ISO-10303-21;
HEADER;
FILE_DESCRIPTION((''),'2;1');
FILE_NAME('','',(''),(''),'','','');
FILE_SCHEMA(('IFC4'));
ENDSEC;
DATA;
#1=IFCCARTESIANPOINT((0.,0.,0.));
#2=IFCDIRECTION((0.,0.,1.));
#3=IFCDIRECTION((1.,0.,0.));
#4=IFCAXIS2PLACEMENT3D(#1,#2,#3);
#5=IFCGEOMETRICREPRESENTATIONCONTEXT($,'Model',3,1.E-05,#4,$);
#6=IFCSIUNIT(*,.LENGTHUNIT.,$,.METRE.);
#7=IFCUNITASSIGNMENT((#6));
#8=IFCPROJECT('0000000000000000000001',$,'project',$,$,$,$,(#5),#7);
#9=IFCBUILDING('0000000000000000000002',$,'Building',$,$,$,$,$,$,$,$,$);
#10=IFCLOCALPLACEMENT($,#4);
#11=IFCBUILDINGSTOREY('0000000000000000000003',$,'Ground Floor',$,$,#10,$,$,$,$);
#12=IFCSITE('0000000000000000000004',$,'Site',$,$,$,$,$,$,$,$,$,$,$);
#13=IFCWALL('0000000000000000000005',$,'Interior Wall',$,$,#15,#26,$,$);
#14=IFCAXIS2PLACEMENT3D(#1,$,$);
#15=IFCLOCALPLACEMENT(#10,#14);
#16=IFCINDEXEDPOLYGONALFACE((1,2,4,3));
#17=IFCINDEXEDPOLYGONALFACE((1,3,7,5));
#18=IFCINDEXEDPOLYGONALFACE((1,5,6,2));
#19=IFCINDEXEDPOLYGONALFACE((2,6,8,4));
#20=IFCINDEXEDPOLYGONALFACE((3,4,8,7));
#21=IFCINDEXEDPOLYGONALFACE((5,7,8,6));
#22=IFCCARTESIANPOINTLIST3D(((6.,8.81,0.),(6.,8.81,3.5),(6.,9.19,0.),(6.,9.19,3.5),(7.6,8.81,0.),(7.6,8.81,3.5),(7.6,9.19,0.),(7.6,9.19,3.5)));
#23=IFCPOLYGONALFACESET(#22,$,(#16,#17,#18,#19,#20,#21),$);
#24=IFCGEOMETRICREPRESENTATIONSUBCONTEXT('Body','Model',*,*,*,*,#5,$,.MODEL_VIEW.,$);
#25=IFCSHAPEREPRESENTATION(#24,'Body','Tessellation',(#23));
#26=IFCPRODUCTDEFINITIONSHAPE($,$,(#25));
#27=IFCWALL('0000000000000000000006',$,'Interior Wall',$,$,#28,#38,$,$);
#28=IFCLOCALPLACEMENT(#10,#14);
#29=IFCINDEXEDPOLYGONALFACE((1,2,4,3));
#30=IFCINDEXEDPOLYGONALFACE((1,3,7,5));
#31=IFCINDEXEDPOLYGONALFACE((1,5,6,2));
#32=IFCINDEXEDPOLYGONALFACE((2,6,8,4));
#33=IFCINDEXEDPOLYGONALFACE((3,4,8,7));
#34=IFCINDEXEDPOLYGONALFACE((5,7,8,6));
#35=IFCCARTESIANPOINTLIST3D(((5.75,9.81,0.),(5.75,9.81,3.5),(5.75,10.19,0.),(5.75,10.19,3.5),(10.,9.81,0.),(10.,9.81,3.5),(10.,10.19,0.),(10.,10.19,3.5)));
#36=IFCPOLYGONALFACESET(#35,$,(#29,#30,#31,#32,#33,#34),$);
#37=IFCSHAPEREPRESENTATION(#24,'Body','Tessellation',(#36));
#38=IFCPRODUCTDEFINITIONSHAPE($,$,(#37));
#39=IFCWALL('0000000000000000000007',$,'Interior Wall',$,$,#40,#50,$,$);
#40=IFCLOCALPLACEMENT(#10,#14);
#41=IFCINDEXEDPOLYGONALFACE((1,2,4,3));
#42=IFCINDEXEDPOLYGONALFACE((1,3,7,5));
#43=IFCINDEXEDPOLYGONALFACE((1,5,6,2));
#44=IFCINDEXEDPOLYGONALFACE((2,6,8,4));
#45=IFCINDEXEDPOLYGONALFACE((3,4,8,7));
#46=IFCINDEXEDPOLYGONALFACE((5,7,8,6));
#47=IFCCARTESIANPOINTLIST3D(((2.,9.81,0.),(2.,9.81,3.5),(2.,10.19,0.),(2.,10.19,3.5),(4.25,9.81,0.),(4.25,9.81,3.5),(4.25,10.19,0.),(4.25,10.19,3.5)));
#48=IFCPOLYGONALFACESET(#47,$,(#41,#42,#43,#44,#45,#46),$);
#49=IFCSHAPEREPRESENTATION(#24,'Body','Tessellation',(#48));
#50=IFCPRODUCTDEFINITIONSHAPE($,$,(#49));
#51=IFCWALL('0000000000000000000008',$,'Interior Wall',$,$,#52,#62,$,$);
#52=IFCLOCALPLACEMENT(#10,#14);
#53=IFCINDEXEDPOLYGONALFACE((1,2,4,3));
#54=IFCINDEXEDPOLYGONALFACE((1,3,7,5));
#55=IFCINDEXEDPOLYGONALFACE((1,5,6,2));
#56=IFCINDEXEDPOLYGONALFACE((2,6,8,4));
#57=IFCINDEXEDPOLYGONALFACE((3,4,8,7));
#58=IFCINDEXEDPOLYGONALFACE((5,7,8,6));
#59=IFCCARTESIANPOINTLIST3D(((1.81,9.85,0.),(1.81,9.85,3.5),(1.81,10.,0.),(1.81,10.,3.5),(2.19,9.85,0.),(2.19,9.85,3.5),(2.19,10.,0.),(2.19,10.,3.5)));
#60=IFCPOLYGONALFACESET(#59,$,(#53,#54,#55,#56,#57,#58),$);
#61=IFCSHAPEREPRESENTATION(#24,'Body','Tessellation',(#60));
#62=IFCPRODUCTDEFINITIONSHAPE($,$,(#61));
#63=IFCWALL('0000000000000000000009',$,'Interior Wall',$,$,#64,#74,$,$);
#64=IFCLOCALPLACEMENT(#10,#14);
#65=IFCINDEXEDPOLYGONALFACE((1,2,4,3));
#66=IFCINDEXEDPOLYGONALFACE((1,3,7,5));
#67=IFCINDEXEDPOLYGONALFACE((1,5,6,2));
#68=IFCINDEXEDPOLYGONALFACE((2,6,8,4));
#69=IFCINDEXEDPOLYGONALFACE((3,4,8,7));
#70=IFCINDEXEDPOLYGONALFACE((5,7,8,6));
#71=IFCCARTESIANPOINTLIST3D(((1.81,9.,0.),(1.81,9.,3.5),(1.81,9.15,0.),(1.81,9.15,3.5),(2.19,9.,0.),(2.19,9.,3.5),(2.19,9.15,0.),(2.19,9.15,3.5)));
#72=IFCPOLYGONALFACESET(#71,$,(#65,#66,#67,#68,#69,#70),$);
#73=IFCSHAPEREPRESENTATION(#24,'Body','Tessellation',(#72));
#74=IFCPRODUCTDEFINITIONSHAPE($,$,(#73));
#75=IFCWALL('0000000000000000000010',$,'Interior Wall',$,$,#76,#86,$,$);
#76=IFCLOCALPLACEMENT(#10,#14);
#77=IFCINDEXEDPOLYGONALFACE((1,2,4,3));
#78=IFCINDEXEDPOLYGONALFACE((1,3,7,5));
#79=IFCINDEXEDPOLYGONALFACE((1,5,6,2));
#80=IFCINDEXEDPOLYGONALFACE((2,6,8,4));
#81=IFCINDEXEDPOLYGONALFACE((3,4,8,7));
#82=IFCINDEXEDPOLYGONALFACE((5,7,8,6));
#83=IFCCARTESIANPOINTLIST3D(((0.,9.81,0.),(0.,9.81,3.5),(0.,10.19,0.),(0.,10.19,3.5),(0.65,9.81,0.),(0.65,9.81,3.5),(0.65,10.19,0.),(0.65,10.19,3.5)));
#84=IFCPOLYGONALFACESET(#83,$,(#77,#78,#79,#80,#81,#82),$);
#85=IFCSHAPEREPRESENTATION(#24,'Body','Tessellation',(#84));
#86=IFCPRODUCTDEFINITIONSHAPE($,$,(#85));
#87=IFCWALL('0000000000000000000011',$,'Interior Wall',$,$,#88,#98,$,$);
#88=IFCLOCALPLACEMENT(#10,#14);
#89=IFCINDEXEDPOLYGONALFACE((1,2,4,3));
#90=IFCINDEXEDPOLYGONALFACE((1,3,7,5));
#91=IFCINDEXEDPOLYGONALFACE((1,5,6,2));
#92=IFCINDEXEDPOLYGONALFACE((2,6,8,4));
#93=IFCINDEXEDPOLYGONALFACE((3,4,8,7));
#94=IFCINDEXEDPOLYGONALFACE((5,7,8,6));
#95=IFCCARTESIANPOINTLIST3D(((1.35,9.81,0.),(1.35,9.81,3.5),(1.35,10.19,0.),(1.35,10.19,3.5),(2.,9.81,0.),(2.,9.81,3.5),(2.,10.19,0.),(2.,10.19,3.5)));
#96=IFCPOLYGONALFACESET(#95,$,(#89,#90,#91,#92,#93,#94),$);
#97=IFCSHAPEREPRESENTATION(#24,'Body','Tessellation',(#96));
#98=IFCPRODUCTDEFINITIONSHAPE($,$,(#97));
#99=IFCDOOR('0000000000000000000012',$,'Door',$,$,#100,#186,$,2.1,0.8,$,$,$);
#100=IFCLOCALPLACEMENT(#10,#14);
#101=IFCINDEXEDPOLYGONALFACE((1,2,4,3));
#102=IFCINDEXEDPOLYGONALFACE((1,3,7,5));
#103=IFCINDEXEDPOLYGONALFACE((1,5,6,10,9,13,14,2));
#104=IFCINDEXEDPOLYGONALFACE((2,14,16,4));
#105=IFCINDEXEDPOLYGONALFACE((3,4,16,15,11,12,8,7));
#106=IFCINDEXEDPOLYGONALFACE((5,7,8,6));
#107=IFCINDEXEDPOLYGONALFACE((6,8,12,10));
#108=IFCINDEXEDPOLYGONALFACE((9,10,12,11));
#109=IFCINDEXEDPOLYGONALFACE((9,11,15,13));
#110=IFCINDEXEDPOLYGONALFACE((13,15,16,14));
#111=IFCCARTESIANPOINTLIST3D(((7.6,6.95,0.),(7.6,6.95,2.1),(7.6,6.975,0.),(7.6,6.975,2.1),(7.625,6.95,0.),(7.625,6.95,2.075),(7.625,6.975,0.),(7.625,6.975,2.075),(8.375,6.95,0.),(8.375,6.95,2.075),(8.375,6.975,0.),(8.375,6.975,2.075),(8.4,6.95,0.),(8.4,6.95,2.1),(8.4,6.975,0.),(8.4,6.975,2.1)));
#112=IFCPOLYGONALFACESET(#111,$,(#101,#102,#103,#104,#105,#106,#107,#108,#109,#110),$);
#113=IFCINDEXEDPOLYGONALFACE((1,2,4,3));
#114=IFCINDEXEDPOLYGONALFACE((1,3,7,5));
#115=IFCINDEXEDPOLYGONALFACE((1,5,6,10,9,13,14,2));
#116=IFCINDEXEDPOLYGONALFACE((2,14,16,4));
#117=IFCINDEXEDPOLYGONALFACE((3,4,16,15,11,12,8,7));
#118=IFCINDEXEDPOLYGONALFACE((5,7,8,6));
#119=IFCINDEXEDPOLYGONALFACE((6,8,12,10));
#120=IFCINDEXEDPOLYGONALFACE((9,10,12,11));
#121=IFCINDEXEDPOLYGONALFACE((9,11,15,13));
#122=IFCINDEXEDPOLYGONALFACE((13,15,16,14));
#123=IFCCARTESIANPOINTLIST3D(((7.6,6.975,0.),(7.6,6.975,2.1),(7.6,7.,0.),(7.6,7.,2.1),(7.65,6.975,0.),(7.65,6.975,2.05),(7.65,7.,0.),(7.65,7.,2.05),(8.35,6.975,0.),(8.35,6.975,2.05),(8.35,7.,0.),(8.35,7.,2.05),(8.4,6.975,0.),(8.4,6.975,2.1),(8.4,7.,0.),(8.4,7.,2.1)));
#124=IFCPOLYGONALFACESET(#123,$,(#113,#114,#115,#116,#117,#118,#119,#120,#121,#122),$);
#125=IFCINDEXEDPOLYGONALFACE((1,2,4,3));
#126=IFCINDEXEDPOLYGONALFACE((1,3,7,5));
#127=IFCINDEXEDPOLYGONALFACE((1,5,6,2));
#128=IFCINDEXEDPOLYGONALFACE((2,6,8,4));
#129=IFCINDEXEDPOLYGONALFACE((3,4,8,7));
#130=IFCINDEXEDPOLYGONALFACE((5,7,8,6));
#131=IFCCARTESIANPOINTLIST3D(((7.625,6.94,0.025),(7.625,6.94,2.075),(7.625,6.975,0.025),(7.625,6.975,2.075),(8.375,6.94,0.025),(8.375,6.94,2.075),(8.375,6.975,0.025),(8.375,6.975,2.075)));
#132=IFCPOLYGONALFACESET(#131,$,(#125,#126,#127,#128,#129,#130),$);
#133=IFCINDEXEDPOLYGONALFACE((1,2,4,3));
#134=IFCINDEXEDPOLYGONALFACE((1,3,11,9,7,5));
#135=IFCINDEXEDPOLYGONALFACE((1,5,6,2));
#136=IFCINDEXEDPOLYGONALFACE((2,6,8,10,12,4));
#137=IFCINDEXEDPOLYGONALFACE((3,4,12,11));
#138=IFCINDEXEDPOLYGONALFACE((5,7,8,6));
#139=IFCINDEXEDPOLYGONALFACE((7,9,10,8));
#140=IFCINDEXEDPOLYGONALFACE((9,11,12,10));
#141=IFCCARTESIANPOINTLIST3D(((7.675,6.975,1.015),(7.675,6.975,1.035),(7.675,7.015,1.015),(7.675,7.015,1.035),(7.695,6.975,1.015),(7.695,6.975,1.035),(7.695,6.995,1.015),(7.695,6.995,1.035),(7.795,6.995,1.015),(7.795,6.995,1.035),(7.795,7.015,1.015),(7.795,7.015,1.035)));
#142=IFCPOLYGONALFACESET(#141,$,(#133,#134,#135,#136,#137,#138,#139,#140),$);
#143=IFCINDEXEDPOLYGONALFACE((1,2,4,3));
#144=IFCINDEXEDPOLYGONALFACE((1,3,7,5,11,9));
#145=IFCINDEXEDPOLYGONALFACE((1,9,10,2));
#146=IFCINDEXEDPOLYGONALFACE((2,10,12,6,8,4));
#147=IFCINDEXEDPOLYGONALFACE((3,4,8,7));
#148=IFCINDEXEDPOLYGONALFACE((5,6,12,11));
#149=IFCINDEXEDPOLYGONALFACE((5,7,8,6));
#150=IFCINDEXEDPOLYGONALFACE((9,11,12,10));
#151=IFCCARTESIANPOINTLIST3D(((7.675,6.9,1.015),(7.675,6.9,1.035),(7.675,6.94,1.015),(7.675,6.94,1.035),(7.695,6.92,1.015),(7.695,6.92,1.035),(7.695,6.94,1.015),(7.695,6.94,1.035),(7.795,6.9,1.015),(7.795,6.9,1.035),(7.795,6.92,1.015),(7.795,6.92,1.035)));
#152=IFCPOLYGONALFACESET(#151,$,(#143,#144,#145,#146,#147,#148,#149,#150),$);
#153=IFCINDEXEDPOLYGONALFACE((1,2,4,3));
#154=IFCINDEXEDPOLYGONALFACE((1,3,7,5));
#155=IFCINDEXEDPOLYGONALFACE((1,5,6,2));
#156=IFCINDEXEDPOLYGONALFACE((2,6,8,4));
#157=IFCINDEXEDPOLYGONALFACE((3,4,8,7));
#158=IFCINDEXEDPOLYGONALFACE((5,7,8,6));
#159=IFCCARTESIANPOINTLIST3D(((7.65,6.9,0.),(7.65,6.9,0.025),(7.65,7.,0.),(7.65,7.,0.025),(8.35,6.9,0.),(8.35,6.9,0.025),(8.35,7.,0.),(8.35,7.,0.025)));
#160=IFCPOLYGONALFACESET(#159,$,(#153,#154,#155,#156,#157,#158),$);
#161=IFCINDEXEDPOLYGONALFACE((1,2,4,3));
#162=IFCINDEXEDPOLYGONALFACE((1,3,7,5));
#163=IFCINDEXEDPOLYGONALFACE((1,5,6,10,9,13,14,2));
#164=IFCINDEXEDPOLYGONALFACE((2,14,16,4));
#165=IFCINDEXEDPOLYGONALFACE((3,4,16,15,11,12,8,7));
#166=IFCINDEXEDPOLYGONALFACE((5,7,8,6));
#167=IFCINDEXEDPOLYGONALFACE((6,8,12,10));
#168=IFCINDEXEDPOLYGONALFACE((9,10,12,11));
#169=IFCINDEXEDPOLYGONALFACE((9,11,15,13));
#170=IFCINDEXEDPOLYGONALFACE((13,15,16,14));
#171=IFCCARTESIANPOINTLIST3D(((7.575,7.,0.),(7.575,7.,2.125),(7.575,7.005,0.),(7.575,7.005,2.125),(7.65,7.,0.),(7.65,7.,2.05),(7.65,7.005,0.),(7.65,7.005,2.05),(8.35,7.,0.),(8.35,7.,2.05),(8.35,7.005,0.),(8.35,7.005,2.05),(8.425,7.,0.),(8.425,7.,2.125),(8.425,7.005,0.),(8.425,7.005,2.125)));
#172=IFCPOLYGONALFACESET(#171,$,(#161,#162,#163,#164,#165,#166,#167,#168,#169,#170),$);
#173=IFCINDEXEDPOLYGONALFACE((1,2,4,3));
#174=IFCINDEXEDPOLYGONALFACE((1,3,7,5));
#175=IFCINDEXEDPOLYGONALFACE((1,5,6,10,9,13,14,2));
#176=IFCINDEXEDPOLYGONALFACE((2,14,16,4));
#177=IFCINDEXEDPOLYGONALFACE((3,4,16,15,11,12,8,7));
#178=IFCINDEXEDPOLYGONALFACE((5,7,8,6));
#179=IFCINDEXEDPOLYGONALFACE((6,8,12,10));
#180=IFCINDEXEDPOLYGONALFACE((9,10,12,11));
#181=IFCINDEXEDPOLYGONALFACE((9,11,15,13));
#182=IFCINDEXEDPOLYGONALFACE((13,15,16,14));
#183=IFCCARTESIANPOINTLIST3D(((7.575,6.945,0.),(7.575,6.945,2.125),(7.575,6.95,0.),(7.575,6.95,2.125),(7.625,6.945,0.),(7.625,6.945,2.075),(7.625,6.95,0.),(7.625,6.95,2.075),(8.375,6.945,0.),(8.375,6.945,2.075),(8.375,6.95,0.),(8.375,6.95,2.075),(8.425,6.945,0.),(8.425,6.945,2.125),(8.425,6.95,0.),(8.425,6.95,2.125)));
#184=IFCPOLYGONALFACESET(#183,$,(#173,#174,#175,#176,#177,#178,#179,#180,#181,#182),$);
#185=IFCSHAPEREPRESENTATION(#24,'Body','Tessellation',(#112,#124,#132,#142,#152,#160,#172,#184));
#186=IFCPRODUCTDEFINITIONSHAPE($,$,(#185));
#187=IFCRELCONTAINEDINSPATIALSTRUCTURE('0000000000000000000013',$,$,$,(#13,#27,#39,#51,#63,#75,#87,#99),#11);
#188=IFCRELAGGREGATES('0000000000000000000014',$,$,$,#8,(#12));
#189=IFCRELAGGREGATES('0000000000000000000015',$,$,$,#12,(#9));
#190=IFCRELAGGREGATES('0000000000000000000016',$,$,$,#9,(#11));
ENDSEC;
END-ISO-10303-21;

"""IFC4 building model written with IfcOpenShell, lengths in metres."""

from ifc_helpers import new_model, si_unit, frame, origin_with_axes, place, context, subcontext, project, spatial, line, indexed_curve, outline, extrude, element, save


model = new_model("IFC4")

# Units and contexts
model_context = context("Model", 3, precision=1e-05, world=origin_with_axes())
body_context = subcontext(model_context, "Body", "Model", "MODEL_VIEW")
ifc_project = project(units=[si_unit("LENGTHUNIT", "METRE")], contexts=[model_context])

# Site, building, storey
site = spatial("IfcSite", under=ifc_project, Name="Site")
building = spatial("IfcBuilding", under=site, Name="Building")
storey_placement = place(None, origin_with_axes())
storey = spatial("IfcBuildingStorey", under=building, at=storey_placement, Name="Ground Floor")

# Walls
for number, where, z_axis, x_axis, name in (
    (1, (7.6, 9.0, 0.0), (0.0, 0.0, 1.0), (-1.0, 0.0, 0.0), "Interior Wall"),
):
    element("IfcWall", number, at=place(storey_placement, frame(where, z_axis=z_axis, x_axis=x_axis)), inside=storey, Name=name, context=body_context, shape_type="SweptSolid", body=[
        extrude(outline(indexed_curve([(0.0, 0.0), (0.0, 0.38), (1.6, 0.38), (1.6, 0.0), (0.0, 0.0)], self_intersect=False)), frame((0.0, -0.19, 0.0), z_axis=(0.0, 0.0, 1.0), x_axis=(1.0, 0.0, 0.0)), (0.0, 0.0, 1.0), 3.5),
    ])
wall_1_placement = place(storey_placement, frame((10.0, 10.0, 0.0), z_axis=(0.0, 0.0, 1.0), x_axis=(-1.0, 0.0, 0.0)))
element("IfcWall", 2, at=wall_1_placement, inside=storey, Name="Interior Wall", context=body_context, shape_type="SweptSolid", body=[
    extrude(outline(indexed_curve([(0.0, 0.0), (0.0, 0.38), (4.25, 0.38), (4.25, 0.0), (0.0, 0.0)], self_intersect=False)), frame((0.0, -0.19, 0.0), z_axis=(0.0, 0.0, 1.0), x_axis=(1.0, 0.0, 0.0)), (0.0, 0.0, 1.0), 3.5),
])
wall_2_placement = place(storey_placement, frame((4.25, 10.0, 0.0), z_axis=(0.0, 0.0, 1.0), x_axis=(-1.0, 0.0, 0.0)))
element("IfcWall", 3, at=wall_2_placement, inside=storey, Name="Interior Wall", context=body_context, shape_type="SweptSolid", body=[
    extrude(outline(indexed_curve([(0.0, 0.0), (0.0, 0.38), (2.25, 0.38), (2.25, 0.0), (0.0, 0.0)], self_intersect=False)), frame((0.0, -0.19, 0.0), z_axis=(0.0, 0.0, 1.0), x_axis=(1.0, 0.0, 0.0)), (0.0, 0.0, 1.0), 3.5),
])
for number, where, z_axis, x_axis, name in (
    (4, (2.0, 10.0, 0.0), (0.0, 0.0, 1.0), (0.0, -1.0, 0.0), "Interior Wall"),
    (5, (2.0, 9.15, 0.0), (0.0, 0.0, 1.0), (0.0, -1.0, 0.0), "Interior Wall"),
):
    element("IfcWall", number, at=place(storey_placement, frame(where, z_axis=z_axis, x_axis=x_axis)), inside=storey, Name=name, context=body_context, shape_type="SweptSolid", body=[
        extrude(outline(indexed_curve([(0.0, 0.0), (0.0, 0.38), (0.15, 0.38), (0.15, 0.0), (0.0, 0.0)], self_intersect=False)), frame((0.0, -0.19, 0.0), z_axis=(0.0, 0.0, 1.0), x_axis=(1.0, 0.0, 0.0)), (0.0, 0.0, 1.0), 3.5),
    ])
wall_3_placement = place(storey_placement, frame((0.0, 10.0, 0.0), z_axis=(0.0, 0.0, 1.0), x_axis=(1.0, 0.0, 0.0)))
element("IfcWall", 6, at=wall_3_placement, inside=storey, Name="Interior Wall", context=body_context, shape_type="SweptSolid", body=[
    extrude(outline(indexed_curve([(0.0, 0.0), (0.0, 0.38), (0.65, 0.38), (0.65, 0.0), (0.0, 0.0)], self_intersect=False)), frame((0.0, -0.19, 0.0), z_axis=(0.0, 0.0, 1.0), x_axis=(1.0, 0.0, 0.0)), (0.0, 0.0, 1.0), 3.5),
])
wall_4_placement = place(storey_placement, frame((1.35, 10.0, 0.0), z_axis=(0.0, 0.0, 1.0), x_axis=(1.0, 0.0, 0.0)))
element("IfcWall", 7, at=wall_4_placement, inside=storey, Name="Interior Wall", context=body_context, shape_type="SweptSolid", body=[
    extrude(outline(indexed_curve([(0.0, 0.0), (0.0, 0.38), (0.65, 0.38), (0.65, 0.0), (0.0, 0.0)], self_intersect=False)), frame((0.0, -0.19, 0.0), z_axis=(0.0, 0.0, 1.0), x_axis=(1.0, 0.0, 0.0)), (0.0, 0.0, 1.0), 3.5),
])

# Door
door_1_placement = place(storey_placement, frame((8.4, 7.0, 0.0), z_axis=(0.0, 0.0, 1.0), x_axis=(-1.0, 0.0, 0.0)))
element("IfcDoor", 8, at=door_1_placement, inside=storey, Name="Door", OverallHeight=2.1, OverallWidth=0.8, context=body_context, shape_type="SweptSolid", body=[
    extrude(outline(indexed_curve([(0.0, 0.0), (0.0, 2.1), (0.8, 2.1), (0.8, 0.0), (0.775, 0.0), (0.775, 2.075), (0.025, 2.075), (0.025, 0.0)], segments=[line(1, 2, 3, 4, 5, 6, 7, 8, 1)])), frame((0.0, 0.025, 0.0), z_axis=(0.0, -1.0, 0.0), x_axis=(1.0, 0.0, 0.0)), (0.0, 0.0, -1.0), 0.025),
    extrude(outline(indexed_curve([(0.0, 0.0), (0.0, 2.1), (0.8, 2.1), (0.8, 0.0), (0.75, 0.0), (0.75, 2.05), (0.05, 2.05), (0.05, 0.0)], segments=[line(1, 2, 3, 4, 5, 6, 7, 8, 1)])), frame((0.0, 0.0, 0.0), z_axis=(0.0, -1.0, 0.0), x_axis=(1.0, 0.0, 0.0)), (0.0, 0.0, -1.0), 0.025),
    extrude(outline(indexed_curve([(0.0, 0.0), (0.75, 0.0), (0.75, 0.035), (0.0, 0.035)], segments=[line(1, 2, 3, 4, 1)])), frame((0.025, 0.025, 0.025), z_axis=(0.0, 0.0, 1.0), x_axis=(1.0, 0.0, 0.0)), (0.0, 0.0, 1.0), 2.05),
    extrude(outline(indexed_curve([(0.0, 0.0), (0.0, -0.04), (-0.12, -0.04), (-0.12, -0.02), (-0.02, -0.02), (-0.02, 0.0)], segments=[line(1, 2, 3, 4, 5, 6, 1)])), frame((0.725, 0.025, 1.015), z_axis=(0.0, 0.0, 1.0), x_axis=(1.0, 0.0, 0.0)), (0.0, 0.0, 1.0), 0.02),
    extrude(outline(indexed_curve([(0.0, 0.0), (0.0, 0.04), (-0.12, 0.04), (-0.12, 0.02), (-0.02, 0.02), (-0.02, 0.0)], segments=[line(1, 2, 3, 4, 5, 6, 1)])), frame((0.725, 0.06, 1.015), z_axis=(0.0, 0.0, 1.0), x_axis=(1.0, 0.0, 0.0)), (0.0, 0.0, 1.0), 0.02),
    extrude(outline(indexed_curve([(0.0, 0.0), (0.7, 0.0), (0.7, 0.1), (0.0, 0.1)], segments=[line(1, 2, 3, 4, 1)])), frame((0.05, 0.0, 0.0), z_axis=(0.0, 0.0, 1.0), x_axis=(1.0, 0.0, 0.0)), (0.0, 0.0, 1.0), 0.025),
    extrude(outline(indexed_curve([(0.0, 0.0), (0.0, 2.125), (0.85, 2.125), (0.85, 0.0), (0.775, 0.0), (0.775, 2.05), (0.075, 2.05), (0.075, 0.0)], segments=[line(1, 2, 3, 4, 5, 6, 7, 8, 1)])), frame((-0.025, -0.005, 0.0), z_axis=(0.0, -1.0, 0.0), x_axis=(1.0, 0.0, 0.0)), (0.0, 0.0, -1.0), 0.005),
    extrude(outline(indexed_curve([(0.0, 0.0), (0.0, 2.125), (0.85, 2.125), (0.85, 0.0), (0.8, 0.0), (0.8, 2.075), (0.05, 2.075), (0.05, 0.0)], segments=[line(1, 2, 3, 4, 5, 6, 7, 8, 1)])), frame((-0.025, 0.05, 0.0), z_axis=(0.0, -1.0, 0.0), x_axis=(1.0, 0.0, 0.0)), (0.0, 0.0, -1.0), 0.005),
])

save(model, "model.ifc")
